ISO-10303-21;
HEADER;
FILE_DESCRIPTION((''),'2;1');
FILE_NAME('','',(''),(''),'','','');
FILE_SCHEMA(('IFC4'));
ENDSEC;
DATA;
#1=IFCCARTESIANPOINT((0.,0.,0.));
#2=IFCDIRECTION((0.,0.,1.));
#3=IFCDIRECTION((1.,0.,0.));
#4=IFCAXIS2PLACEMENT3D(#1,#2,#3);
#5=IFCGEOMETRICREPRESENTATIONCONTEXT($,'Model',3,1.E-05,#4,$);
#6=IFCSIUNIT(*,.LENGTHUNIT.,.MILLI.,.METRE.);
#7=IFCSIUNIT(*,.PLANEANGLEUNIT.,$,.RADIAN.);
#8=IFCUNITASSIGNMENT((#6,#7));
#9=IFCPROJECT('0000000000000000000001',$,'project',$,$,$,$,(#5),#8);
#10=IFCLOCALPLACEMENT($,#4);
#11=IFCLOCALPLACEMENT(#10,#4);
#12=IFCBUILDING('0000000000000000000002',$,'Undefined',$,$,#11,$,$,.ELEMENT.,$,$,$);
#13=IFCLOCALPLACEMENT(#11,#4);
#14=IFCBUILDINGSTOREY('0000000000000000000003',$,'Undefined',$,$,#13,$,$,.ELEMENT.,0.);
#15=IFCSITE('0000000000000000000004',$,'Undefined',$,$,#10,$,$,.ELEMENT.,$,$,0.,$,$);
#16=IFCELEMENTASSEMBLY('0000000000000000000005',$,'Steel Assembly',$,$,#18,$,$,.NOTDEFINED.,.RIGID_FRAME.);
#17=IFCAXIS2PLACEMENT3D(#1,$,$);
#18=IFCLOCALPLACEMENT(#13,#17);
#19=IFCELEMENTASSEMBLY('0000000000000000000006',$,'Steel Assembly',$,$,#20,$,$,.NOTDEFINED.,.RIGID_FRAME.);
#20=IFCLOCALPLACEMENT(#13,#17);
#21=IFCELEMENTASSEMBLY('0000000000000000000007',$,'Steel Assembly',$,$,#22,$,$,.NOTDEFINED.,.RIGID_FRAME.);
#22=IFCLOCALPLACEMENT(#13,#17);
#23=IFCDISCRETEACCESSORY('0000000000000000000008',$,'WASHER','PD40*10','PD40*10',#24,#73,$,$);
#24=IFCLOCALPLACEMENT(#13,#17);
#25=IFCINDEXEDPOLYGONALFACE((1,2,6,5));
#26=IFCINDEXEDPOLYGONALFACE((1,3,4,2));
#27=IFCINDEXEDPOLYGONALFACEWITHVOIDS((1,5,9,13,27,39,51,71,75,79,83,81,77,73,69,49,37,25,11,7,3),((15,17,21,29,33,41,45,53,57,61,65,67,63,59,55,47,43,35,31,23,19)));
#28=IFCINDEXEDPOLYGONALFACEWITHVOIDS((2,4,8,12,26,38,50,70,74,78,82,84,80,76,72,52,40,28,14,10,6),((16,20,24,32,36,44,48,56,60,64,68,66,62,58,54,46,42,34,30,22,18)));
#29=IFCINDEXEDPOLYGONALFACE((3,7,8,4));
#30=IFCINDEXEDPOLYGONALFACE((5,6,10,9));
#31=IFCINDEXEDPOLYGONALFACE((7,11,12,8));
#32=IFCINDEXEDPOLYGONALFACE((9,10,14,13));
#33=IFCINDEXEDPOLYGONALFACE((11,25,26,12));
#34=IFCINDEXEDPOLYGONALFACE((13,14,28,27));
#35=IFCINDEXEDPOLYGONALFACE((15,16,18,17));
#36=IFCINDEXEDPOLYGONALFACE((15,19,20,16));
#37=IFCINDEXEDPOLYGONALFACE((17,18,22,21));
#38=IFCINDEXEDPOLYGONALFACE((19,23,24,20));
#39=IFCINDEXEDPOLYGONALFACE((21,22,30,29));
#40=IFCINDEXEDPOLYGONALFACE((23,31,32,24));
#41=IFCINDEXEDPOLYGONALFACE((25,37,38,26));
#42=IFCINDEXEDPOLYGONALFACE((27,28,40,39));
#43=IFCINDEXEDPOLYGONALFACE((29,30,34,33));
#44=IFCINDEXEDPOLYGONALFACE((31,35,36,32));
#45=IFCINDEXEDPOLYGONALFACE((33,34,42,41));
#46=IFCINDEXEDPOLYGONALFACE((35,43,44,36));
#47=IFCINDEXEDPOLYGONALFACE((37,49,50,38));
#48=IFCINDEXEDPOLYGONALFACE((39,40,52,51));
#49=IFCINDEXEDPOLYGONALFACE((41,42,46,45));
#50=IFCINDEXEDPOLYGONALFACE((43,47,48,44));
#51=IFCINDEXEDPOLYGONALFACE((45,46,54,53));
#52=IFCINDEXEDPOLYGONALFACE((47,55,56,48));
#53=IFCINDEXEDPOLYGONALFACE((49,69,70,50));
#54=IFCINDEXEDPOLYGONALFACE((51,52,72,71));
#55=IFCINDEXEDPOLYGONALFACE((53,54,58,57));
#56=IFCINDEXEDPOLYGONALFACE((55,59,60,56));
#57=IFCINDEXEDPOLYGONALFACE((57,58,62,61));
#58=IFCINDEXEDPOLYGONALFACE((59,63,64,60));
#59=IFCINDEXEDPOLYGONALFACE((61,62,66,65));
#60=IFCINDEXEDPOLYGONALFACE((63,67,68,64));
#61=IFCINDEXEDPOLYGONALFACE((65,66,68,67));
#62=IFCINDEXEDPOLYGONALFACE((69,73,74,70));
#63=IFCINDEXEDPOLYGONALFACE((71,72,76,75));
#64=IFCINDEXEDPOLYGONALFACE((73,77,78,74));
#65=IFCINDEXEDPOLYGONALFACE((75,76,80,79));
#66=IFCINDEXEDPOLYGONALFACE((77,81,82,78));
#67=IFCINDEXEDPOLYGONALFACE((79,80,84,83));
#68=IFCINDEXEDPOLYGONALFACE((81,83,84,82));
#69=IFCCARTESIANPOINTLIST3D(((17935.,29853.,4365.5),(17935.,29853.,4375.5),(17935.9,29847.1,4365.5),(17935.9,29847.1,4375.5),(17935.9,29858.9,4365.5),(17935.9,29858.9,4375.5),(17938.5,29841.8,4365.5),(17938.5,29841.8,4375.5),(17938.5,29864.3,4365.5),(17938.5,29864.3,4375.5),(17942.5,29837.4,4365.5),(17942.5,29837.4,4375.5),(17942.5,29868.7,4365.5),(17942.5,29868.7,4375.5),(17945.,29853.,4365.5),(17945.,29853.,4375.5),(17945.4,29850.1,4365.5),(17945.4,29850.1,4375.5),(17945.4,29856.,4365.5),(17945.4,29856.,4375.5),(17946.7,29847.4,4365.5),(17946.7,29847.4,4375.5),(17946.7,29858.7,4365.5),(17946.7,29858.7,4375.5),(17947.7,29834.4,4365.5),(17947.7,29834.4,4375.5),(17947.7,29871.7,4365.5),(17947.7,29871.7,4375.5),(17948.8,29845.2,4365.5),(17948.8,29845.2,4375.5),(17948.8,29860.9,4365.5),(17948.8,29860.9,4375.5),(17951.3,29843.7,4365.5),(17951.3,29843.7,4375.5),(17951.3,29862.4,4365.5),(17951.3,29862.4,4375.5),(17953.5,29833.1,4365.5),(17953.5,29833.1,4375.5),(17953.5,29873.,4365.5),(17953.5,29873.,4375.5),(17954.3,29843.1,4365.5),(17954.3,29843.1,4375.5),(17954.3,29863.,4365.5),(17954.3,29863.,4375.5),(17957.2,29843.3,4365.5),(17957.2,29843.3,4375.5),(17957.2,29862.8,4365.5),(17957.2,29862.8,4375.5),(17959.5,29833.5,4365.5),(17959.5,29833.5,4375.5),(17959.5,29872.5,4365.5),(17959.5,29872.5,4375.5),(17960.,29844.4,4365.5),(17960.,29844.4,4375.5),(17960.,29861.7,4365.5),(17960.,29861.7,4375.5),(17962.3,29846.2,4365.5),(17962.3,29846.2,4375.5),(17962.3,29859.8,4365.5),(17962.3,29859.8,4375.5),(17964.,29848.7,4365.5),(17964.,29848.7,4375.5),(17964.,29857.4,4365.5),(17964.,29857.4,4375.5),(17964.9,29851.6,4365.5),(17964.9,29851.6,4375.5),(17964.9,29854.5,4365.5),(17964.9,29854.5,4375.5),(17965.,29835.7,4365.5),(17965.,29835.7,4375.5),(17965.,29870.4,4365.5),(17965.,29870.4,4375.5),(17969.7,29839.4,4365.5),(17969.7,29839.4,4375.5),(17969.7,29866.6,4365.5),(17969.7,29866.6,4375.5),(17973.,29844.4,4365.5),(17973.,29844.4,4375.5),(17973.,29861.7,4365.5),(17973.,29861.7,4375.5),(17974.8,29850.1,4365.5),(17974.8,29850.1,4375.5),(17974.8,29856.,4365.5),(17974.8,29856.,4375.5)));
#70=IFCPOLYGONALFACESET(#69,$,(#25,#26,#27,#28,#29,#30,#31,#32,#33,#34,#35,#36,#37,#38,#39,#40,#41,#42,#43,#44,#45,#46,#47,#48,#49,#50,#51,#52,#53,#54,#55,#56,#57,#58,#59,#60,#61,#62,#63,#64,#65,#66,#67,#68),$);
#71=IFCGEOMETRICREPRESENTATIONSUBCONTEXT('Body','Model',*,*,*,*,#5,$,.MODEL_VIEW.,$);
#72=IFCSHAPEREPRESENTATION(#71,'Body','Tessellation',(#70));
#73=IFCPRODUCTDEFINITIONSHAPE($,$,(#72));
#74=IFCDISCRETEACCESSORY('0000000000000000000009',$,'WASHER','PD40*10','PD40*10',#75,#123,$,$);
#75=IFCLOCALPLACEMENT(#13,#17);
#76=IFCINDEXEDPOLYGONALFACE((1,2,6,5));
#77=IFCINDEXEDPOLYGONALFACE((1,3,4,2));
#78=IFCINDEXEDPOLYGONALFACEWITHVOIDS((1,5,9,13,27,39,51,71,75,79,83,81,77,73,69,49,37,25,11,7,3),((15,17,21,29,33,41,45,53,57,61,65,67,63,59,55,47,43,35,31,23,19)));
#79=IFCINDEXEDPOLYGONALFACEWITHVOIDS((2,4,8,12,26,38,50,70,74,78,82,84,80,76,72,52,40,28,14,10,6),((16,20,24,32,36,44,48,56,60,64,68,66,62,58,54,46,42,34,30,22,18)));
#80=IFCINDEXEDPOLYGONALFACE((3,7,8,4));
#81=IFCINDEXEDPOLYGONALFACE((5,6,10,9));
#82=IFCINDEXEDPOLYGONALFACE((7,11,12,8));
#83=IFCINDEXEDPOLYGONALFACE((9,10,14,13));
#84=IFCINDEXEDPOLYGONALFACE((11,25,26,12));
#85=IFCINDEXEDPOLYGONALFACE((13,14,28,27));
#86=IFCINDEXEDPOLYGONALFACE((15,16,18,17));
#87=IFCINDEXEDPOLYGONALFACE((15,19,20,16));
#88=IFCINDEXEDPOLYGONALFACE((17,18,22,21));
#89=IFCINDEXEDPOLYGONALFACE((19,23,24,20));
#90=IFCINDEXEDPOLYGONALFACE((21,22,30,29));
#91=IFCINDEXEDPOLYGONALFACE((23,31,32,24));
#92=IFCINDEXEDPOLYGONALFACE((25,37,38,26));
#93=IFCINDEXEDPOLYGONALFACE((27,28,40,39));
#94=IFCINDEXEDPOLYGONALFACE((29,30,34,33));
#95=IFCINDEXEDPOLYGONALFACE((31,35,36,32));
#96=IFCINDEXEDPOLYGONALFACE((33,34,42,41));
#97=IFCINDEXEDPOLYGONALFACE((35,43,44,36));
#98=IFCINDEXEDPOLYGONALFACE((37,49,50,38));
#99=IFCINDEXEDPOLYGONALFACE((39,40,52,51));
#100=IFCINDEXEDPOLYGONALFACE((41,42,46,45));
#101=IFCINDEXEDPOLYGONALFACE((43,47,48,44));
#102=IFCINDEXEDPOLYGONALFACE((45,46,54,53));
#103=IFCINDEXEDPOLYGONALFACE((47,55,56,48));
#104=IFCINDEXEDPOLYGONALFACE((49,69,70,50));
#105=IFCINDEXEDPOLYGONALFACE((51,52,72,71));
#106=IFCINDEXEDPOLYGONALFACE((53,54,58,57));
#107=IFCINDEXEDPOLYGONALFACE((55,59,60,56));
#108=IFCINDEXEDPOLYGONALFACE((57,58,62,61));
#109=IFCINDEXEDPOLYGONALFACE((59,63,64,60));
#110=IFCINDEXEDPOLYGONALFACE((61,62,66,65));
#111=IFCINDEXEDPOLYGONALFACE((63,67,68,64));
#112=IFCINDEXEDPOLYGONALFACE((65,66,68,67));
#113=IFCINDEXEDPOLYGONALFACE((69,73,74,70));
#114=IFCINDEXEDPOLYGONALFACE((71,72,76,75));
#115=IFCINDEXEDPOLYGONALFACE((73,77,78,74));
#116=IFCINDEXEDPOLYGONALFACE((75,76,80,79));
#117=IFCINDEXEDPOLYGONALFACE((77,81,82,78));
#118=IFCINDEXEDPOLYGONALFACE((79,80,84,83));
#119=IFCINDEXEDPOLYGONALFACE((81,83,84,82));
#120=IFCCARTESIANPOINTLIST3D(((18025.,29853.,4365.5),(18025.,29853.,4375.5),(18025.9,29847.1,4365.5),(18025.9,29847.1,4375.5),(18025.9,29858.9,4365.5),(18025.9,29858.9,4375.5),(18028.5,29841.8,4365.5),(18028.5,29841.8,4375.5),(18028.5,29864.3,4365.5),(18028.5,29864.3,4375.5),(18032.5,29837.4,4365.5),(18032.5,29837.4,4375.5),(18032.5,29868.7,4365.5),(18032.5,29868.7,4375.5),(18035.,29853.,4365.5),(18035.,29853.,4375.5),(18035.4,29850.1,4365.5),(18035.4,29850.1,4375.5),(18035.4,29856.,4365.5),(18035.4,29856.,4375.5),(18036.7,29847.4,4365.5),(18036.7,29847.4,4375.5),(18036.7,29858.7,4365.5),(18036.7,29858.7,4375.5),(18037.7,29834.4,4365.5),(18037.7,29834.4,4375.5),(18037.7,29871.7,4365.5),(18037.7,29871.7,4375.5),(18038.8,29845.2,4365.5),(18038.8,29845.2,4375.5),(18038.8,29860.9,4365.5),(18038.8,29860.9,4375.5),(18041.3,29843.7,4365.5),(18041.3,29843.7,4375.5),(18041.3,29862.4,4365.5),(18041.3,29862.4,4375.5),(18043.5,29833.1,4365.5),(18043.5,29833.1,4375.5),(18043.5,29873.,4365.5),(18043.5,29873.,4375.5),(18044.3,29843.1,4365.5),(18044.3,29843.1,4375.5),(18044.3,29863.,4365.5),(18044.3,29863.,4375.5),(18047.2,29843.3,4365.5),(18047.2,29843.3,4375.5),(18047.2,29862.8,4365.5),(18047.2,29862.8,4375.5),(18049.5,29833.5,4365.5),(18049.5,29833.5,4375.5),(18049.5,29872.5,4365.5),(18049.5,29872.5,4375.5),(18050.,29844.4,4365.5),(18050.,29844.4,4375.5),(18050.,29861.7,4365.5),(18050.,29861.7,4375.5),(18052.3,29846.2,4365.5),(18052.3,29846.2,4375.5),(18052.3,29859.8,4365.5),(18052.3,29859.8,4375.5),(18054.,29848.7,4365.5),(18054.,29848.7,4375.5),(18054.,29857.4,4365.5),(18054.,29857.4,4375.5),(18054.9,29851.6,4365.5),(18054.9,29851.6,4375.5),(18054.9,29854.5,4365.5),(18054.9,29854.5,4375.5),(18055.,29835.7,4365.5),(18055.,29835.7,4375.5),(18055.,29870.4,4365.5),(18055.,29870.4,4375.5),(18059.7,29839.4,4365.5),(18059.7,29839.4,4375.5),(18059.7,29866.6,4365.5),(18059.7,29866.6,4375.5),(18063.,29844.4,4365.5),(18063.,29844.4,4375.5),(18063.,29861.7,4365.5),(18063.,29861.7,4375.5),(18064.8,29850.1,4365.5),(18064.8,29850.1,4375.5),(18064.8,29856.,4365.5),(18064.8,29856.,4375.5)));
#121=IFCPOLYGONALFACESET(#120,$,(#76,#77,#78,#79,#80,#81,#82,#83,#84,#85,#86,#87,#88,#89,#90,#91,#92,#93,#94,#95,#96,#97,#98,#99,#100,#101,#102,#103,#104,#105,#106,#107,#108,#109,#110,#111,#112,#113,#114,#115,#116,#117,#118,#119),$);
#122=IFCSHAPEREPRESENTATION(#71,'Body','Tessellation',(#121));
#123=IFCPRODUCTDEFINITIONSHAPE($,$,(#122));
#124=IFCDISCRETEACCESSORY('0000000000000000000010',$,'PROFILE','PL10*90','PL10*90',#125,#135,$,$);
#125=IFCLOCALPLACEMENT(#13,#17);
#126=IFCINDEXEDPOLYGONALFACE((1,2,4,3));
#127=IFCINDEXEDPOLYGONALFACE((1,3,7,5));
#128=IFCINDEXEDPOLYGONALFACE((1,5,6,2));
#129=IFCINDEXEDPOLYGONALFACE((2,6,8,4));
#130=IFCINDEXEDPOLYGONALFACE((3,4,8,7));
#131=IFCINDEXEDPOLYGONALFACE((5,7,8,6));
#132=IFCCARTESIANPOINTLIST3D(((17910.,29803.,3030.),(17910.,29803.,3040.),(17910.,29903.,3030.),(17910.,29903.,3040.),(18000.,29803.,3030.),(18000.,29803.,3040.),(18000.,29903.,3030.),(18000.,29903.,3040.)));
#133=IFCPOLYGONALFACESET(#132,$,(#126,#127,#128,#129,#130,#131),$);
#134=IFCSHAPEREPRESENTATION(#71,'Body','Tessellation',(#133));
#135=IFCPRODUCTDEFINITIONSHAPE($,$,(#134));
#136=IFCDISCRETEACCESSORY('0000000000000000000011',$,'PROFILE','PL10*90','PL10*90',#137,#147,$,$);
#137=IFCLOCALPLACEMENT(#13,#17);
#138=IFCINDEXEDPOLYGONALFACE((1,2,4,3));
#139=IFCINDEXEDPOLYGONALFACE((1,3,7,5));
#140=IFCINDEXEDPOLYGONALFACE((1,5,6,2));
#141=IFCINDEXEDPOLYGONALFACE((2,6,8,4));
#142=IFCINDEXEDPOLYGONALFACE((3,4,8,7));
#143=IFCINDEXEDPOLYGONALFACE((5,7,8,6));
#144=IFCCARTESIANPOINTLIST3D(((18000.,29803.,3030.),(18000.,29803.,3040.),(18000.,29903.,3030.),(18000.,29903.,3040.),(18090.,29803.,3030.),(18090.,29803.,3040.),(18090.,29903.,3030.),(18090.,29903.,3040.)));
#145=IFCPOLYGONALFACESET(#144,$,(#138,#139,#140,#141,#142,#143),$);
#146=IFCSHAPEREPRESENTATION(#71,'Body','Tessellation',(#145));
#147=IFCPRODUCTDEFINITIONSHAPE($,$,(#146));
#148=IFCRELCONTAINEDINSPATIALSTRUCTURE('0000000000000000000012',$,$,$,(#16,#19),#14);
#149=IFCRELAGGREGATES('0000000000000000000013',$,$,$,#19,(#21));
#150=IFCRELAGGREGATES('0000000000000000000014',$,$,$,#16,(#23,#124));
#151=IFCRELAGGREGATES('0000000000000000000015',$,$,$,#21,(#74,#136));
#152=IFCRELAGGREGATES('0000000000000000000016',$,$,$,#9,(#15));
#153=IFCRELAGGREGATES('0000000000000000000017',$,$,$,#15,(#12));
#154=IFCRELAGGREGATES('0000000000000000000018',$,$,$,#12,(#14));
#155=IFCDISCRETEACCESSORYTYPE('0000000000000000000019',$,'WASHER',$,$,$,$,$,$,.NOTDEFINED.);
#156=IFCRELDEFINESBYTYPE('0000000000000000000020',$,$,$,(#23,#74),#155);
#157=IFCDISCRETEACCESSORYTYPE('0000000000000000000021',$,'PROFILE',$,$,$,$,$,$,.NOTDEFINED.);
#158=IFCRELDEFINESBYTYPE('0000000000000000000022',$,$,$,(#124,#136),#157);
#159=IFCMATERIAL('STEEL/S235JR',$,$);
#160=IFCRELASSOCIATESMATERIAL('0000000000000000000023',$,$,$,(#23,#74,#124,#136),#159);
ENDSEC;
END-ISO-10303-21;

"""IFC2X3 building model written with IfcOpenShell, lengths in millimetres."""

from ifc_helpers import new_model, si_unit, frame, origin_with_axes, origin_2d_with_axis, place, context, subcontext, project, spatial, polyline, hollow_circle, outline, extrude, material, type_object, element, aggregate, save


model = new_model("IFC2X3")

# Units and contexts
model_context = context("Model", 3, precision=1e-05, world=origin_with_axes())
body_context = subcontext(model_context, "Body", "Model", "MODEL_VIEW")
ifc_project = project(units=[si_unit("LENGTHUNIT", "METRE", prefix="MILLI"), si_unit("PLANEANGLEUNIT", "RADIAN")], contexts=[model_context])

# Site, building, storey
site_placement = place(None, origin_with_axes())
site = spatial("IfcSite", under=ifc_project, at=site_placement, Name="Undefined", CompositionType="ELEMENT", RefElevation=0.0)
building_placement = place(site_placement, origin_with_axes())
building = spatial("IfcBuilding", under=site, at=building_placement, Name="Undefined", CompositionType="ELEMENT")
storey_placement = place(building_placement, origin_with_axes())
storey = spatial("IfcBuildingStorey", under=building, at=storey_placement, Name="Undefined", CompositionType="ELEMENT", Elevation=0.0)

# Element assembly
assembly_1_placement = place(storey_placement, origin_with_axes())
assembly_1 = element("IfcElementAssembly", 1, at=assembly_1_placement, inside=storey, Name="Steel Assembly", AssemblyPlace="NOTDEFINED", PredefinedType="RIGID_FRAME")

# Element assemblies
assembly_2_placement = place(storey_placement, origin_with_axes())
assembly_2 = element("IfcElementAssembly", 2, at=assembly_2_placement, inside=storey, Name="Steel Assembly", AssemblyPlace="NOTDEFINED", PredefinedType="RIGID_FRAME")
assembly_3_placement = place(assembly_2_placement, origin_with_axes())
assembly_3 = element("IfcElementAssembly", 3, at=assembly_3_placement, Name="Steel Assembly", AssemblyPlace="NOTDEFINED", PredefinedType="RIGID_FRAME")

# Shared definitions
ifc_material_1 = material(Name="STEEL/S235JR")

aggregate(assembly_2, [assembly_3])

# Discrete accessories
discrete_accessory_type_1 = type_object("IfcDiscreteAccessoryType", Name="WASHER")
discrete_accessory_1_placement = place(assembly_1_placement, frame((17955.0, 29853.0, 4375.5), z_axis=(0.0, -1.0, 0.0), x_axis=(0.0, 0.0, -1.0)))
discrete_accessory_1 = element("IfcDiscreteAccessory", 4, at=discrete_accessory_1_placement, type_object=discrete_accessory_type_1, material=ifc_material_1, Name="WASHER", Description="PD40*10", ObjectType="PD40*10", context=body_context, shape_type="SweptSolid", body=[
    extrude(hollow_circle(Radius=20.0, WallThickness=10.0, at=origin_2d_with_axis()), frame((10.0, 0.0, 0.0), z_axis=(-1.0, 0.0, 0.0), x_axis=(0.0, -1.0, 0.0)), (0.0, 0.0, 1.0), 10.0),
])
discrete_accessory_2_placement = place(assembly_3_placement, frame((18045.0, 29853.0, 4375.5), z_axis=(0.0, -1.0, 0.0), x_axis=(0.0, 0.0, -1.0)))
discrete_accessory_2 = element("IfcDiscreteAccessory", 5, at=discrete_accessory_2_placement, type_object=discrete_accessory_type_1, material=ifc_material_1, Name="WASHER", Description="PD40*10", ObjectType="PD40*10", context=body_context, shape_type="SweptSolid", body=[
    extrude(hollow_circle(Radius=20.0, WallThickness=10.0, at=origin_2d_with_axis()), frame((10.0, 0.0, 0.0), z_axis=(-1.0, 0.0, 0.0), x_axis=(0.0, -1.0, 0.0)), (0.0, 0.0, 1.0), 10.0),
])
discrete_accessory_type_2 = type_object("IfcDiscreteAccessoryType", Name="PROFILE")
discrete_accessory_3_placement = place(assembly_1_placement, frame((17955.0, 29903.0, 3035.0), z_axis=(0.0, 0.0, 1.0), x_axis=(0.0, -1.0, 0.0)))
discrete_accessory_3 = element("IfcDiscreteAccessory", 6, at=discrete_accessory_3_placement, type_object=discrete_accessory_type_2, material=ifc_material_1, Name="PROFILE", Description="PL10*90", ObjectType="PL10*90", context=body_context, shape_type="SweptSolid", body=[
    extrude(outline(polyline([(100.0, -45.0), (0.0, -45.0), (0.0, 45.0), (100.0, 45.0), (100.0, -45.0)])), frame((0.0, 0.0, -5.0), z_axis=(0.0, 0.0, 1.0), x_axis=(1.0, 0.0, 0.0)), (0.0, 0.0, 1.0), 10.0),
])
aggregate(assembly_1, [discrete_accessory_1, discrete_accessory_3])
discrete_accessory_4_placement = place(assembly_3_placement, frame((18045.0, 29903.0, 3035.0), z_axis=(0.0, 0.0, 1.0), x_axis=(0.0, -1.0, 0.0)))
discrete_accessory_4 = element("IfcDiscreteAccessory", 7, at=discrete_accessory_4_placement, type_object=discrete_accessory_type_2, material=ifc_material_1, Name="PROFILE", Description="PL10*90", ObjectType="PL10*90", context=body_context, shape_type="SweptSolid", body=[
    extrude(outline(polyline([(100.0, -45.0), (0.0, -45.0), (0.0, 45.0), (100.0, 45.0), (100.0, -45.0)])), frame((0.0, 0.0, -5.0), z_axis=(0.0, 0.0, 1.0), x_axis=(1.0, 0.0, 0.0)), (0.0, 0.0, 1.0), 10.0),
])
aggregate(assembly_3, [discrete_accessory_2, discrete_accessory_4])

save(model, "model.ifc")
